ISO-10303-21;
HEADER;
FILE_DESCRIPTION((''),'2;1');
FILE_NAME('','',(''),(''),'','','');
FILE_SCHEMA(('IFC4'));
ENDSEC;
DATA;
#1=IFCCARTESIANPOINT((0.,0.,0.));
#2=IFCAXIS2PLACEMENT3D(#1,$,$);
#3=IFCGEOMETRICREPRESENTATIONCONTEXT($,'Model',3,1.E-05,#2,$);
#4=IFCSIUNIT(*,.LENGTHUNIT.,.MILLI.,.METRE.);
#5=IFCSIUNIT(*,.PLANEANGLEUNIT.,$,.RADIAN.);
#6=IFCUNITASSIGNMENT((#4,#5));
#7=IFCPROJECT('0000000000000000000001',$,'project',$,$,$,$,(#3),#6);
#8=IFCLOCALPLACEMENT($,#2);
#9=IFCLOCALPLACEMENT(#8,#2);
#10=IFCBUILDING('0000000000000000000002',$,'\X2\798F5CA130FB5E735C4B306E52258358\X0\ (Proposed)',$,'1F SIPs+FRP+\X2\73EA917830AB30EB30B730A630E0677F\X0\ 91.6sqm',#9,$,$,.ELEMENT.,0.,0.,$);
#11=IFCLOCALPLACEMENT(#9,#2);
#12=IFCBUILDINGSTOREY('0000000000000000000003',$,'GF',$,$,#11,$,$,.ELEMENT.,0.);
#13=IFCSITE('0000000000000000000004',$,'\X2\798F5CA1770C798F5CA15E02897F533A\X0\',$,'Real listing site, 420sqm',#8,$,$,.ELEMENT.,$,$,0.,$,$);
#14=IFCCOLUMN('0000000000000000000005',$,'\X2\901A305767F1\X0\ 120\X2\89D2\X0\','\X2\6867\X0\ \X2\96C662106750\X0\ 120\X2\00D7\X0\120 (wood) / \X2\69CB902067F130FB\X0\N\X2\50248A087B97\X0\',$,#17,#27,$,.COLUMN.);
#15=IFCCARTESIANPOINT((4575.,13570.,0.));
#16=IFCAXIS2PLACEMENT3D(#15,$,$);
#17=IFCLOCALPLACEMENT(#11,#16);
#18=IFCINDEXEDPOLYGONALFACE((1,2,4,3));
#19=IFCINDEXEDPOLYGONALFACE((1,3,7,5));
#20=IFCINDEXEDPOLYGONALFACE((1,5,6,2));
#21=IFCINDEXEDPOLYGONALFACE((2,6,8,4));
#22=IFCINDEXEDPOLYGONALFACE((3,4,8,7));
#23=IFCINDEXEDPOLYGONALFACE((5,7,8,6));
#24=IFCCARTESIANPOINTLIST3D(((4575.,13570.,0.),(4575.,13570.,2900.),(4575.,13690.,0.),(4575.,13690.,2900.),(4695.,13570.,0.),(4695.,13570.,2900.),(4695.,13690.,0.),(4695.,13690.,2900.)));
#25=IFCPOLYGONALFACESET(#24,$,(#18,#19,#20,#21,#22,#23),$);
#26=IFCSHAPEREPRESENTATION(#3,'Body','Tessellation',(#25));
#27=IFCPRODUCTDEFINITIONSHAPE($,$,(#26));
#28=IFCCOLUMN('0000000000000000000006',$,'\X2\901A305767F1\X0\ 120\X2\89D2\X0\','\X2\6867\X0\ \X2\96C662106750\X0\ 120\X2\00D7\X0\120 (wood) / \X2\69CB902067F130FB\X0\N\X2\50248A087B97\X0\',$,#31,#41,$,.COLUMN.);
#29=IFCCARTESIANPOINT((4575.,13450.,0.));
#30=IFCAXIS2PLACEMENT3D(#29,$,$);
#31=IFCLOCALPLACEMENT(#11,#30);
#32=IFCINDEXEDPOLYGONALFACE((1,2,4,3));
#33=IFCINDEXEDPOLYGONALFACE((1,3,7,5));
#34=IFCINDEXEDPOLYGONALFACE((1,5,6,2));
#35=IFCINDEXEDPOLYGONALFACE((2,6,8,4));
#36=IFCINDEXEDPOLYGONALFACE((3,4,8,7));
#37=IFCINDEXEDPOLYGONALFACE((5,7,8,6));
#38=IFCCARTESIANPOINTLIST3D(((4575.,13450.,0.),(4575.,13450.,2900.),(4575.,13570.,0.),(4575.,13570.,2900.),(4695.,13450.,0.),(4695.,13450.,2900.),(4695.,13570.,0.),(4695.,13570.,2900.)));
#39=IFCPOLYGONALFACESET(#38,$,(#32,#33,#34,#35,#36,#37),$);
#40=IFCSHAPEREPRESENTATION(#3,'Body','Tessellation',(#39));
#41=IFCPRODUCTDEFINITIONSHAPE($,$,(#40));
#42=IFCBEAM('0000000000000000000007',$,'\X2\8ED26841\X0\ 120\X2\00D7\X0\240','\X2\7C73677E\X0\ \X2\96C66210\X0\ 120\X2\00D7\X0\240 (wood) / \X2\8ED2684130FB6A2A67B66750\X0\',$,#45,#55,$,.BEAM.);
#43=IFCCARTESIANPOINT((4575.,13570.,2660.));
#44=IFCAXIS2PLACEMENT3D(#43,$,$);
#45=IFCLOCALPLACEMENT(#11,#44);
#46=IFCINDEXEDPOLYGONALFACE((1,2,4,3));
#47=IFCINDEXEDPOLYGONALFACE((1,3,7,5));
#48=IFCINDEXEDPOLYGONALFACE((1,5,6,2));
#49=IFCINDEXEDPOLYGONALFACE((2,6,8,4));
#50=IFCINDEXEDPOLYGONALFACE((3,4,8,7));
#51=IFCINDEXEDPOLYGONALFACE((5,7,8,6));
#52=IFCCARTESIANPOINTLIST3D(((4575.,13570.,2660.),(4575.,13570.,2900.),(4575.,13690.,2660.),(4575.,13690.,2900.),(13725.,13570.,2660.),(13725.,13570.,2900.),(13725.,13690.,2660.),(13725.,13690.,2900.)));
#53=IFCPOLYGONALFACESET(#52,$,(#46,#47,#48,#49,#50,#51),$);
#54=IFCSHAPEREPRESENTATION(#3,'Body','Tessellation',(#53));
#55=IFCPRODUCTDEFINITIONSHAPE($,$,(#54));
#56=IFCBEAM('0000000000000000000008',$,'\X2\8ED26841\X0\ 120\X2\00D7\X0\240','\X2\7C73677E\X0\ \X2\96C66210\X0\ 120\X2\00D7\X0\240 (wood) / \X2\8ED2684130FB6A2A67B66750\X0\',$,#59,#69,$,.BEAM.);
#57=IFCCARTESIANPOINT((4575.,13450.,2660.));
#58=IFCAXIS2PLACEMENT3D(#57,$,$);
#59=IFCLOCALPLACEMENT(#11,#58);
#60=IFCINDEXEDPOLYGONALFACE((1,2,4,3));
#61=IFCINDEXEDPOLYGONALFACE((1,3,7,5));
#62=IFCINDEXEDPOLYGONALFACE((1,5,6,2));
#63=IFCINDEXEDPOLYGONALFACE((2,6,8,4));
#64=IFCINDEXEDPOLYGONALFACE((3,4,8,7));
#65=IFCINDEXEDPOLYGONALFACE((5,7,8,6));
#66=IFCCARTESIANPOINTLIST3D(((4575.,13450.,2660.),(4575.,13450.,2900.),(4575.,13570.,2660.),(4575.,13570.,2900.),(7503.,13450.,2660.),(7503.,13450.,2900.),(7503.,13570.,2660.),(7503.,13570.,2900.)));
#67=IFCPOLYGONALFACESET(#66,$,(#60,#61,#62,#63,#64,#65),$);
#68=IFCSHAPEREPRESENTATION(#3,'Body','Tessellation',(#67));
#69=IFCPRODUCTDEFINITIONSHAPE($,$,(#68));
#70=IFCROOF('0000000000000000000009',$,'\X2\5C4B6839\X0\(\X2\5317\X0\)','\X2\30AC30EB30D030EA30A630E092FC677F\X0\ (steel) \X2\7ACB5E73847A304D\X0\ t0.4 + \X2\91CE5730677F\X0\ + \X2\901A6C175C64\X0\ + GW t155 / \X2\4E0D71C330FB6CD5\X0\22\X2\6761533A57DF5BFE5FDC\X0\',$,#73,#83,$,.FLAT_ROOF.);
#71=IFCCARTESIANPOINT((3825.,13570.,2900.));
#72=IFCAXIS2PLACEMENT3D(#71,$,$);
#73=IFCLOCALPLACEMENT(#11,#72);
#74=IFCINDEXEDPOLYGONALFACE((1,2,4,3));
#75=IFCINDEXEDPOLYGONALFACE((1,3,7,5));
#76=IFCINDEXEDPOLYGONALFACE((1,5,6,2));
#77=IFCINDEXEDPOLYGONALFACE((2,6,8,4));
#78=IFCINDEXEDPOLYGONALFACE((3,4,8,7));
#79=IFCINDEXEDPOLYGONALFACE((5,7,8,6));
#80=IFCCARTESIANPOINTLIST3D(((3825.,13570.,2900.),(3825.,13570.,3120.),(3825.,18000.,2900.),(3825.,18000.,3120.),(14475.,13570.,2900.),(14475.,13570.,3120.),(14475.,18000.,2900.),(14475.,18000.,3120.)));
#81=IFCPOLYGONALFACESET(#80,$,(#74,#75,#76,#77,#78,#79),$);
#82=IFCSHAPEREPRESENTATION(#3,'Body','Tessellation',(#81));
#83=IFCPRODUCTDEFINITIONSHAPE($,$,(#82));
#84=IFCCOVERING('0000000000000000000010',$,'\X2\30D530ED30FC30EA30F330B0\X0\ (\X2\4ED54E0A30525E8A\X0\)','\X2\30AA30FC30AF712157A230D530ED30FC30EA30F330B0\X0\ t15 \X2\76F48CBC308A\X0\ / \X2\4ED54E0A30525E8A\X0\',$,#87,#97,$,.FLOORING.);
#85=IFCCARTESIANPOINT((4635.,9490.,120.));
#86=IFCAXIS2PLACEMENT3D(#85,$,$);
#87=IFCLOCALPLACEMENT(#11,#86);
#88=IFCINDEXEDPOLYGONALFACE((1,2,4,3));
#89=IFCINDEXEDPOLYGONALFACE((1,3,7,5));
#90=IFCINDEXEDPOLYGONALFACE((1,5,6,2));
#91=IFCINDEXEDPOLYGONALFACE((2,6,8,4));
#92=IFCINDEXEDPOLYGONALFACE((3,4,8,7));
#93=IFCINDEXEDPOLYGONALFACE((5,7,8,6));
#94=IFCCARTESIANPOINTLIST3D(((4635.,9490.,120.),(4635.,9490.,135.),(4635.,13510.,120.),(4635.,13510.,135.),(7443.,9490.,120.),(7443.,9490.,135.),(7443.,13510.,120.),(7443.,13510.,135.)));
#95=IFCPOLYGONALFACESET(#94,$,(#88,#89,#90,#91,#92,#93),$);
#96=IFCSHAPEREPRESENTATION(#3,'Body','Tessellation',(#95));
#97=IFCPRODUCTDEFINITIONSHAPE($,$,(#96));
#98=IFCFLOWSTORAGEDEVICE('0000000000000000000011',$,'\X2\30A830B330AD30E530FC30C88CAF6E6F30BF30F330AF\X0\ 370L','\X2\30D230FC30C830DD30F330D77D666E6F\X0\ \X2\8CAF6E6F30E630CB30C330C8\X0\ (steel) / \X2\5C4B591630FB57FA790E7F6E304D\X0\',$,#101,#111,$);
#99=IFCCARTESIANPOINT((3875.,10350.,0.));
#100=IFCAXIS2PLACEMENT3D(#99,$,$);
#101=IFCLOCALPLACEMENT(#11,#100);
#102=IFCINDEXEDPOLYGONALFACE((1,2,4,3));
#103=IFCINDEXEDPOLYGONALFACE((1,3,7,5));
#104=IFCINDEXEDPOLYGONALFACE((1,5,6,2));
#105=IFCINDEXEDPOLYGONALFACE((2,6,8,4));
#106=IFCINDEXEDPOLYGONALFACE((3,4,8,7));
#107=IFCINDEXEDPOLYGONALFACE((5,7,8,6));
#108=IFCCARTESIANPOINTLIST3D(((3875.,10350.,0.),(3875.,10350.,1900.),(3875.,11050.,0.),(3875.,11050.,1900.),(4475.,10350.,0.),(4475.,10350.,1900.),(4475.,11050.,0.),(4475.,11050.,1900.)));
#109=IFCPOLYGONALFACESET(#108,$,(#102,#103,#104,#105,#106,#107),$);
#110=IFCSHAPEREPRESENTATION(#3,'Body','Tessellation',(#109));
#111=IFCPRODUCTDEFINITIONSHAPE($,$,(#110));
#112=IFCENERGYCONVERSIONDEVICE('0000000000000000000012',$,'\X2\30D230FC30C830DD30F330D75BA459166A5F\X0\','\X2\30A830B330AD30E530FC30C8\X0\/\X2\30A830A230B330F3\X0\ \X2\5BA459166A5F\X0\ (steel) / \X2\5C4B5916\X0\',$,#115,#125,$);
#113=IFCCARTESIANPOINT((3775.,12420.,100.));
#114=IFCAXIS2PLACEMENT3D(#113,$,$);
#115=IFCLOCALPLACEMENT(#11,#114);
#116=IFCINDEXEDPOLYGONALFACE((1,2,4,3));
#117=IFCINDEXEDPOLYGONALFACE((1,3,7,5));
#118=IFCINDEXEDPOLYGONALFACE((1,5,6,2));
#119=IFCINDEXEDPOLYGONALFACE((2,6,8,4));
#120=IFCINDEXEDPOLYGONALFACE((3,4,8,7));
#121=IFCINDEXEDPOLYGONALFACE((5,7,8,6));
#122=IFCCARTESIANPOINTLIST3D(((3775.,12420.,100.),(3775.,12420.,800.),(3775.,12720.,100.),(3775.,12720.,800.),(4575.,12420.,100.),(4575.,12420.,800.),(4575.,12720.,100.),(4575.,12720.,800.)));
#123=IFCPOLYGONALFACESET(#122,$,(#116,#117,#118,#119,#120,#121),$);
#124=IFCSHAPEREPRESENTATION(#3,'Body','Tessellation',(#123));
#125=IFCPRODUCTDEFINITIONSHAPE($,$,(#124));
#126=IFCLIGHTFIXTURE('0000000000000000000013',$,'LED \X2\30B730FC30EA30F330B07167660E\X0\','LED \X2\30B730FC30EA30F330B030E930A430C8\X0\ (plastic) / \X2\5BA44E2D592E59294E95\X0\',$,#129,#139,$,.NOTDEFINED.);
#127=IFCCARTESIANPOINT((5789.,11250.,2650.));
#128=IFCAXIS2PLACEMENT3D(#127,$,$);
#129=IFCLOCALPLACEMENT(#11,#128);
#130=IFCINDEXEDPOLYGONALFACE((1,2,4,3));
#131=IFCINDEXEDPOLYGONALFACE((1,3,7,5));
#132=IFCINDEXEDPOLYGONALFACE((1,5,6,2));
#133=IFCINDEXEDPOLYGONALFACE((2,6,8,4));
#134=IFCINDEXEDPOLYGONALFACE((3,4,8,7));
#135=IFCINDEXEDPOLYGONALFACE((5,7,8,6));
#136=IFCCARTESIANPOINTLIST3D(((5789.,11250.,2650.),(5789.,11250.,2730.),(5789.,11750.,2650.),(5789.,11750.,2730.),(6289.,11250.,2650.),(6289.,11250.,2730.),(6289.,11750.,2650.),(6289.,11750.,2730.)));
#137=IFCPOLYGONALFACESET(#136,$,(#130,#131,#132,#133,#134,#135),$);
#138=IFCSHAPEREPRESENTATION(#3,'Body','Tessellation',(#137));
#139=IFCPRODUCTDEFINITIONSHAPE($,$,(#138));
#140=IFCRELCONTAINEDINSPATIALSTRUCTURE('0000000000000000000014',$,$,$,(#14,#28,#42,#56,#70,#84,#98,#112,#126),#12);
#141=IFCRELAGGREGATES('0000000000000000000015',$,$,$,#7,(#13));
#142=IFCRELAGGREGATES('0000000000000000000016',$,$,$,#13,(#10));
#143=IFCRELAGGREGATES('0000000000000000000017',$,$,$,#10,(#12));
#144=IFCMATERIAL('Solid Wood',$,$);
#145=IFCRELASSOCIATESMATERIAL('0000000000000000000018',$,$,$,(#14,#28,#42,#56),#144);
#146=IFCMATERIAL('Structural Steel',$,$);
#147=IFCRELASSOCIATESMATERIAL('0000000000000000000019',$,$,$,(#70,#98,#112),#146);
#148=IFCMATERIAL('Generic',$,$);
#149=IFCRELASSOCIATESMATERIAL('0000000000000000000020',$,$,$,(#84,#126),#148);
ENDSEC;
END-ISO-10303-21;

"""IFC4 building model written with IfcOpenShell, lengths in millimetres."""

from ifc_helpers import new_model, si_unit, frame, frame_2d, origin, place, context, project, spatial, rectangle, extrude, material, element, save


model = new_model("IFC4")

# Units and contexts
model_context = context("Model", 3, precision=1e-05, world=origin())
ifc_project = project(units=[si_unit("LENGTHUNIT", "METRE", prefix="MILLI"), si_unit("PLANEANGLEUNIT", "RADIAN")], contexts=[model_context])

# Site, building, storey
site_placement = place(None, origin())
site = spatial("IfcSite", under=ifc_project, at=site_placement, Name="福岡県福岡市西区", ObjectType="Real listing site, 420sqm", CompositionType="ELEMENT", RefElevation=0.0)
building_placement = place(site_placement, origin())
building = spatial("IfcBuilding", under=site, at=building_placement, Name="福岡・平屋の別荘 (Proposed)", ObjectType="1F SIPs+FRP+珪酸カルシウム板 91.6sqm", CompositionType="ELEMENT", ElevationOfRefHeight=0.0, ElevationOfTerrain=0.0)
storey_placement = place(building_placement, origin())
storey = spatial("IfcBuildingStorey", under=building, at=storey_placement, Name="GF", CompositionType="ELEMENT", Elevation=0.0)

# Columns
ifc_material_1 = material(Name="Solid Wood")
column_1_placement = place(storey_placement, frame((4575.0, 13570.0, 0.0)))
element("IfcColumn", 1, at=column_1_placement, inside=storey, material=ifc_material_1, Name="通し柱 120角", Description="桧 集成材 120×120 (wood) / 構造柱・N値計算", PredefinedType="COLUMN", context=model_context, shape_type="SweptSolid", body=[
    extrude(rectangle(XDim=120.0, YDim=120.0, at=frame_2d((60.0, 60.0))), frame((4575.0, 13570.0, 0.0)), (0.0, 0.0, 1.0), 2900.0),
])
column_2_placement = place(storey_placement, frame((4575.0, 13450.0, 0.0)))
element("IfcColumn", 2, at=column_2_placement, inside=storey, material=ifc_material_1, Name="通し柱 120角", Description="桧 集成材 120×120 (wood) / 構造柱・N値計算", PredefinedType="COLUMN", context=model_context, shape_type="SweptSolid", body=[
    extrude(rectangle(XDim=120.0, YDim=120.0, at=frame_2d((60.0, 60.0))), frame((4575.0, 13450.0, 0.0)), (0.0, 0.0, 1.0), 2900.0),
])

# Beams
beam_1_placement = place(storey_placement, frame((4575.0, 13570.0, 2660.0)))
element("IfcBeam", 3, at=beam_1_placement, inside=storey, material=ifc_material_1, Name="軒桁 120×240", Description="米松 集成 120×240 (wood) / 軒桁・横架材", PredefinedType="BEAM", context=model_context, shape_type="SweptSolid", body=[
    extrude(rectangle(XDim=9150.0, YDim=120.0, at=frame_2d((4575.0, 60.0))), frame((4575.0, 13570.0, 2660.0)), (0.0, 0.0, 1.0), 240.0),
])
beam_2_placement = place(storey_placement, frame((4575.0, 13450.0, 2660.0)))
element("IfcBeam", 4, at=beam_2_placement, inside=storey, material=ifc_material_1, Name="軒桁 120×240", Description="米松 集成 120×240 (wood) / 軒桁・横架材", PredefinedType="BEAM", context=model_context, shape_type="SweptSolid", body=[
    extrude(rectangle(XDim=2928.0, YDim=120.0, at=frame_2d((1464.0, 60.0))), frame((4575.0, 13450.0, 2660.0)), (0.0, 0.0, 1.0), 240.0),
])

# Roof
ifc_material_2 = material(Name="Structural Steel")
roof_placement = place(storey_placement, frame((3825.0, 13570.0, 2900.0)))
element("IfcRoof", 5, at=roof_placement, inside=storey, material=ifc_material_2, Name="屋根(北)", Description="ガルバリウム鋼板 (steel) 立平葺き t0.4 + 野地板 + 通気層 + GW t155 / 不燃・法22条区域対応", PredefinedType="FLAT_ROOF", context=model_context, shape_type="SweptSolid", body=[
    extrude(rectangle(XDim=10650.0, YDim=4430.0, at=frame_2d((5325.0, 2215.0))), frame((3825.0, 13570.0, 2900.0)), (0.0, 0.0, 1.0), 220.0),
])

# Covering
ifc_material_3 = material(Name="Generic")
covering_placement = place(storey_placement, frame((4635.0, 9490.0, 120.0)))
element("IfcCovering", 6, at=covering_placement, inside=storey, material=ifc_material_3, Name="フローリング (仕上げ床)", Description="オーク無垢フローリング t15 直貼り / 仕上げ床", PredefinedType="FLOORING", context=model_context, shape_type="SweptSolid", body=[
    extrude(rectangle(XDim=2808.0, YDim=4020.0, at=frame_2d((1404.0, 2010.0))), frame((4635.0, 9490.0, 120.0)), (0.0, 0.0, 1.0), 15.0),
])

# Flow storage device
flow_storage_device_placement = place(storey_placement, frame((3875.0, 10350.0, 0.0)))
element("IfcFlowStorageDevice", 7, at=flow_storage_device_placement, inside=storey, material=ifc_material_2, Name="エコキュート貯湯タンク 370L", Description="ヒートポンプ給湯 貯湯ユニット (steel) / 屋外・基礎置き", context=model_context, shape_type="SweptSolid", body=[
    extrude(rectangle(XDim=600.0, YDim=700.0, at=frame_2d((300.0, 350.0))), frame((3875.0, 10350.0, 0.0)), (0.0, 0.0, 1.0), 1900.0),
])

# Energy conversion device
energy_conversion_device_placement = place(storey_placement, frame((3775.0, 12420.0, 100.0)))
element("IfcEnergyConversionDevice", 8, at=energy_conversion_device_placement, inside=storey, material=ifc_material_2, Name="ヒートポンプ室外機", Description="エコキュート/エアコン 室外機 (steel) / 屋外", context=model_context, shape_type="SweptSolid", body=[
    extrude(rectangle(XDim=800.0, YDim=300.0, at=frame_2d((400.0, 150.0))), frame((3775.0, 12420.0, 100.0)), (0.0, 0.0, 1.0), 700.0),
])

# Light fixture
light_fixture_placement = place(storey_placement, frame((5789.0, 11250.0, 2650.0)))
element("IfcLightFixture", 9, at=light_fixture_placement, inside=storey, material=ifc_material_3, Name="LED シーリング照明", Description="LED シーリングライト (plastic) / 室中央天井", PredefinedType="NOTDEFINED", context=model_context, shape_type="SweptSolid", body=[
    extrude(rectangle(XDim=500.0, YDim=500.0, at=frame_2d((250.0, 250.0))), frame((5789.0, 11250.0, 2650.0)), (0.0, 0.0, 1.0), 80.0),
])

save(model, "model.ifc")
